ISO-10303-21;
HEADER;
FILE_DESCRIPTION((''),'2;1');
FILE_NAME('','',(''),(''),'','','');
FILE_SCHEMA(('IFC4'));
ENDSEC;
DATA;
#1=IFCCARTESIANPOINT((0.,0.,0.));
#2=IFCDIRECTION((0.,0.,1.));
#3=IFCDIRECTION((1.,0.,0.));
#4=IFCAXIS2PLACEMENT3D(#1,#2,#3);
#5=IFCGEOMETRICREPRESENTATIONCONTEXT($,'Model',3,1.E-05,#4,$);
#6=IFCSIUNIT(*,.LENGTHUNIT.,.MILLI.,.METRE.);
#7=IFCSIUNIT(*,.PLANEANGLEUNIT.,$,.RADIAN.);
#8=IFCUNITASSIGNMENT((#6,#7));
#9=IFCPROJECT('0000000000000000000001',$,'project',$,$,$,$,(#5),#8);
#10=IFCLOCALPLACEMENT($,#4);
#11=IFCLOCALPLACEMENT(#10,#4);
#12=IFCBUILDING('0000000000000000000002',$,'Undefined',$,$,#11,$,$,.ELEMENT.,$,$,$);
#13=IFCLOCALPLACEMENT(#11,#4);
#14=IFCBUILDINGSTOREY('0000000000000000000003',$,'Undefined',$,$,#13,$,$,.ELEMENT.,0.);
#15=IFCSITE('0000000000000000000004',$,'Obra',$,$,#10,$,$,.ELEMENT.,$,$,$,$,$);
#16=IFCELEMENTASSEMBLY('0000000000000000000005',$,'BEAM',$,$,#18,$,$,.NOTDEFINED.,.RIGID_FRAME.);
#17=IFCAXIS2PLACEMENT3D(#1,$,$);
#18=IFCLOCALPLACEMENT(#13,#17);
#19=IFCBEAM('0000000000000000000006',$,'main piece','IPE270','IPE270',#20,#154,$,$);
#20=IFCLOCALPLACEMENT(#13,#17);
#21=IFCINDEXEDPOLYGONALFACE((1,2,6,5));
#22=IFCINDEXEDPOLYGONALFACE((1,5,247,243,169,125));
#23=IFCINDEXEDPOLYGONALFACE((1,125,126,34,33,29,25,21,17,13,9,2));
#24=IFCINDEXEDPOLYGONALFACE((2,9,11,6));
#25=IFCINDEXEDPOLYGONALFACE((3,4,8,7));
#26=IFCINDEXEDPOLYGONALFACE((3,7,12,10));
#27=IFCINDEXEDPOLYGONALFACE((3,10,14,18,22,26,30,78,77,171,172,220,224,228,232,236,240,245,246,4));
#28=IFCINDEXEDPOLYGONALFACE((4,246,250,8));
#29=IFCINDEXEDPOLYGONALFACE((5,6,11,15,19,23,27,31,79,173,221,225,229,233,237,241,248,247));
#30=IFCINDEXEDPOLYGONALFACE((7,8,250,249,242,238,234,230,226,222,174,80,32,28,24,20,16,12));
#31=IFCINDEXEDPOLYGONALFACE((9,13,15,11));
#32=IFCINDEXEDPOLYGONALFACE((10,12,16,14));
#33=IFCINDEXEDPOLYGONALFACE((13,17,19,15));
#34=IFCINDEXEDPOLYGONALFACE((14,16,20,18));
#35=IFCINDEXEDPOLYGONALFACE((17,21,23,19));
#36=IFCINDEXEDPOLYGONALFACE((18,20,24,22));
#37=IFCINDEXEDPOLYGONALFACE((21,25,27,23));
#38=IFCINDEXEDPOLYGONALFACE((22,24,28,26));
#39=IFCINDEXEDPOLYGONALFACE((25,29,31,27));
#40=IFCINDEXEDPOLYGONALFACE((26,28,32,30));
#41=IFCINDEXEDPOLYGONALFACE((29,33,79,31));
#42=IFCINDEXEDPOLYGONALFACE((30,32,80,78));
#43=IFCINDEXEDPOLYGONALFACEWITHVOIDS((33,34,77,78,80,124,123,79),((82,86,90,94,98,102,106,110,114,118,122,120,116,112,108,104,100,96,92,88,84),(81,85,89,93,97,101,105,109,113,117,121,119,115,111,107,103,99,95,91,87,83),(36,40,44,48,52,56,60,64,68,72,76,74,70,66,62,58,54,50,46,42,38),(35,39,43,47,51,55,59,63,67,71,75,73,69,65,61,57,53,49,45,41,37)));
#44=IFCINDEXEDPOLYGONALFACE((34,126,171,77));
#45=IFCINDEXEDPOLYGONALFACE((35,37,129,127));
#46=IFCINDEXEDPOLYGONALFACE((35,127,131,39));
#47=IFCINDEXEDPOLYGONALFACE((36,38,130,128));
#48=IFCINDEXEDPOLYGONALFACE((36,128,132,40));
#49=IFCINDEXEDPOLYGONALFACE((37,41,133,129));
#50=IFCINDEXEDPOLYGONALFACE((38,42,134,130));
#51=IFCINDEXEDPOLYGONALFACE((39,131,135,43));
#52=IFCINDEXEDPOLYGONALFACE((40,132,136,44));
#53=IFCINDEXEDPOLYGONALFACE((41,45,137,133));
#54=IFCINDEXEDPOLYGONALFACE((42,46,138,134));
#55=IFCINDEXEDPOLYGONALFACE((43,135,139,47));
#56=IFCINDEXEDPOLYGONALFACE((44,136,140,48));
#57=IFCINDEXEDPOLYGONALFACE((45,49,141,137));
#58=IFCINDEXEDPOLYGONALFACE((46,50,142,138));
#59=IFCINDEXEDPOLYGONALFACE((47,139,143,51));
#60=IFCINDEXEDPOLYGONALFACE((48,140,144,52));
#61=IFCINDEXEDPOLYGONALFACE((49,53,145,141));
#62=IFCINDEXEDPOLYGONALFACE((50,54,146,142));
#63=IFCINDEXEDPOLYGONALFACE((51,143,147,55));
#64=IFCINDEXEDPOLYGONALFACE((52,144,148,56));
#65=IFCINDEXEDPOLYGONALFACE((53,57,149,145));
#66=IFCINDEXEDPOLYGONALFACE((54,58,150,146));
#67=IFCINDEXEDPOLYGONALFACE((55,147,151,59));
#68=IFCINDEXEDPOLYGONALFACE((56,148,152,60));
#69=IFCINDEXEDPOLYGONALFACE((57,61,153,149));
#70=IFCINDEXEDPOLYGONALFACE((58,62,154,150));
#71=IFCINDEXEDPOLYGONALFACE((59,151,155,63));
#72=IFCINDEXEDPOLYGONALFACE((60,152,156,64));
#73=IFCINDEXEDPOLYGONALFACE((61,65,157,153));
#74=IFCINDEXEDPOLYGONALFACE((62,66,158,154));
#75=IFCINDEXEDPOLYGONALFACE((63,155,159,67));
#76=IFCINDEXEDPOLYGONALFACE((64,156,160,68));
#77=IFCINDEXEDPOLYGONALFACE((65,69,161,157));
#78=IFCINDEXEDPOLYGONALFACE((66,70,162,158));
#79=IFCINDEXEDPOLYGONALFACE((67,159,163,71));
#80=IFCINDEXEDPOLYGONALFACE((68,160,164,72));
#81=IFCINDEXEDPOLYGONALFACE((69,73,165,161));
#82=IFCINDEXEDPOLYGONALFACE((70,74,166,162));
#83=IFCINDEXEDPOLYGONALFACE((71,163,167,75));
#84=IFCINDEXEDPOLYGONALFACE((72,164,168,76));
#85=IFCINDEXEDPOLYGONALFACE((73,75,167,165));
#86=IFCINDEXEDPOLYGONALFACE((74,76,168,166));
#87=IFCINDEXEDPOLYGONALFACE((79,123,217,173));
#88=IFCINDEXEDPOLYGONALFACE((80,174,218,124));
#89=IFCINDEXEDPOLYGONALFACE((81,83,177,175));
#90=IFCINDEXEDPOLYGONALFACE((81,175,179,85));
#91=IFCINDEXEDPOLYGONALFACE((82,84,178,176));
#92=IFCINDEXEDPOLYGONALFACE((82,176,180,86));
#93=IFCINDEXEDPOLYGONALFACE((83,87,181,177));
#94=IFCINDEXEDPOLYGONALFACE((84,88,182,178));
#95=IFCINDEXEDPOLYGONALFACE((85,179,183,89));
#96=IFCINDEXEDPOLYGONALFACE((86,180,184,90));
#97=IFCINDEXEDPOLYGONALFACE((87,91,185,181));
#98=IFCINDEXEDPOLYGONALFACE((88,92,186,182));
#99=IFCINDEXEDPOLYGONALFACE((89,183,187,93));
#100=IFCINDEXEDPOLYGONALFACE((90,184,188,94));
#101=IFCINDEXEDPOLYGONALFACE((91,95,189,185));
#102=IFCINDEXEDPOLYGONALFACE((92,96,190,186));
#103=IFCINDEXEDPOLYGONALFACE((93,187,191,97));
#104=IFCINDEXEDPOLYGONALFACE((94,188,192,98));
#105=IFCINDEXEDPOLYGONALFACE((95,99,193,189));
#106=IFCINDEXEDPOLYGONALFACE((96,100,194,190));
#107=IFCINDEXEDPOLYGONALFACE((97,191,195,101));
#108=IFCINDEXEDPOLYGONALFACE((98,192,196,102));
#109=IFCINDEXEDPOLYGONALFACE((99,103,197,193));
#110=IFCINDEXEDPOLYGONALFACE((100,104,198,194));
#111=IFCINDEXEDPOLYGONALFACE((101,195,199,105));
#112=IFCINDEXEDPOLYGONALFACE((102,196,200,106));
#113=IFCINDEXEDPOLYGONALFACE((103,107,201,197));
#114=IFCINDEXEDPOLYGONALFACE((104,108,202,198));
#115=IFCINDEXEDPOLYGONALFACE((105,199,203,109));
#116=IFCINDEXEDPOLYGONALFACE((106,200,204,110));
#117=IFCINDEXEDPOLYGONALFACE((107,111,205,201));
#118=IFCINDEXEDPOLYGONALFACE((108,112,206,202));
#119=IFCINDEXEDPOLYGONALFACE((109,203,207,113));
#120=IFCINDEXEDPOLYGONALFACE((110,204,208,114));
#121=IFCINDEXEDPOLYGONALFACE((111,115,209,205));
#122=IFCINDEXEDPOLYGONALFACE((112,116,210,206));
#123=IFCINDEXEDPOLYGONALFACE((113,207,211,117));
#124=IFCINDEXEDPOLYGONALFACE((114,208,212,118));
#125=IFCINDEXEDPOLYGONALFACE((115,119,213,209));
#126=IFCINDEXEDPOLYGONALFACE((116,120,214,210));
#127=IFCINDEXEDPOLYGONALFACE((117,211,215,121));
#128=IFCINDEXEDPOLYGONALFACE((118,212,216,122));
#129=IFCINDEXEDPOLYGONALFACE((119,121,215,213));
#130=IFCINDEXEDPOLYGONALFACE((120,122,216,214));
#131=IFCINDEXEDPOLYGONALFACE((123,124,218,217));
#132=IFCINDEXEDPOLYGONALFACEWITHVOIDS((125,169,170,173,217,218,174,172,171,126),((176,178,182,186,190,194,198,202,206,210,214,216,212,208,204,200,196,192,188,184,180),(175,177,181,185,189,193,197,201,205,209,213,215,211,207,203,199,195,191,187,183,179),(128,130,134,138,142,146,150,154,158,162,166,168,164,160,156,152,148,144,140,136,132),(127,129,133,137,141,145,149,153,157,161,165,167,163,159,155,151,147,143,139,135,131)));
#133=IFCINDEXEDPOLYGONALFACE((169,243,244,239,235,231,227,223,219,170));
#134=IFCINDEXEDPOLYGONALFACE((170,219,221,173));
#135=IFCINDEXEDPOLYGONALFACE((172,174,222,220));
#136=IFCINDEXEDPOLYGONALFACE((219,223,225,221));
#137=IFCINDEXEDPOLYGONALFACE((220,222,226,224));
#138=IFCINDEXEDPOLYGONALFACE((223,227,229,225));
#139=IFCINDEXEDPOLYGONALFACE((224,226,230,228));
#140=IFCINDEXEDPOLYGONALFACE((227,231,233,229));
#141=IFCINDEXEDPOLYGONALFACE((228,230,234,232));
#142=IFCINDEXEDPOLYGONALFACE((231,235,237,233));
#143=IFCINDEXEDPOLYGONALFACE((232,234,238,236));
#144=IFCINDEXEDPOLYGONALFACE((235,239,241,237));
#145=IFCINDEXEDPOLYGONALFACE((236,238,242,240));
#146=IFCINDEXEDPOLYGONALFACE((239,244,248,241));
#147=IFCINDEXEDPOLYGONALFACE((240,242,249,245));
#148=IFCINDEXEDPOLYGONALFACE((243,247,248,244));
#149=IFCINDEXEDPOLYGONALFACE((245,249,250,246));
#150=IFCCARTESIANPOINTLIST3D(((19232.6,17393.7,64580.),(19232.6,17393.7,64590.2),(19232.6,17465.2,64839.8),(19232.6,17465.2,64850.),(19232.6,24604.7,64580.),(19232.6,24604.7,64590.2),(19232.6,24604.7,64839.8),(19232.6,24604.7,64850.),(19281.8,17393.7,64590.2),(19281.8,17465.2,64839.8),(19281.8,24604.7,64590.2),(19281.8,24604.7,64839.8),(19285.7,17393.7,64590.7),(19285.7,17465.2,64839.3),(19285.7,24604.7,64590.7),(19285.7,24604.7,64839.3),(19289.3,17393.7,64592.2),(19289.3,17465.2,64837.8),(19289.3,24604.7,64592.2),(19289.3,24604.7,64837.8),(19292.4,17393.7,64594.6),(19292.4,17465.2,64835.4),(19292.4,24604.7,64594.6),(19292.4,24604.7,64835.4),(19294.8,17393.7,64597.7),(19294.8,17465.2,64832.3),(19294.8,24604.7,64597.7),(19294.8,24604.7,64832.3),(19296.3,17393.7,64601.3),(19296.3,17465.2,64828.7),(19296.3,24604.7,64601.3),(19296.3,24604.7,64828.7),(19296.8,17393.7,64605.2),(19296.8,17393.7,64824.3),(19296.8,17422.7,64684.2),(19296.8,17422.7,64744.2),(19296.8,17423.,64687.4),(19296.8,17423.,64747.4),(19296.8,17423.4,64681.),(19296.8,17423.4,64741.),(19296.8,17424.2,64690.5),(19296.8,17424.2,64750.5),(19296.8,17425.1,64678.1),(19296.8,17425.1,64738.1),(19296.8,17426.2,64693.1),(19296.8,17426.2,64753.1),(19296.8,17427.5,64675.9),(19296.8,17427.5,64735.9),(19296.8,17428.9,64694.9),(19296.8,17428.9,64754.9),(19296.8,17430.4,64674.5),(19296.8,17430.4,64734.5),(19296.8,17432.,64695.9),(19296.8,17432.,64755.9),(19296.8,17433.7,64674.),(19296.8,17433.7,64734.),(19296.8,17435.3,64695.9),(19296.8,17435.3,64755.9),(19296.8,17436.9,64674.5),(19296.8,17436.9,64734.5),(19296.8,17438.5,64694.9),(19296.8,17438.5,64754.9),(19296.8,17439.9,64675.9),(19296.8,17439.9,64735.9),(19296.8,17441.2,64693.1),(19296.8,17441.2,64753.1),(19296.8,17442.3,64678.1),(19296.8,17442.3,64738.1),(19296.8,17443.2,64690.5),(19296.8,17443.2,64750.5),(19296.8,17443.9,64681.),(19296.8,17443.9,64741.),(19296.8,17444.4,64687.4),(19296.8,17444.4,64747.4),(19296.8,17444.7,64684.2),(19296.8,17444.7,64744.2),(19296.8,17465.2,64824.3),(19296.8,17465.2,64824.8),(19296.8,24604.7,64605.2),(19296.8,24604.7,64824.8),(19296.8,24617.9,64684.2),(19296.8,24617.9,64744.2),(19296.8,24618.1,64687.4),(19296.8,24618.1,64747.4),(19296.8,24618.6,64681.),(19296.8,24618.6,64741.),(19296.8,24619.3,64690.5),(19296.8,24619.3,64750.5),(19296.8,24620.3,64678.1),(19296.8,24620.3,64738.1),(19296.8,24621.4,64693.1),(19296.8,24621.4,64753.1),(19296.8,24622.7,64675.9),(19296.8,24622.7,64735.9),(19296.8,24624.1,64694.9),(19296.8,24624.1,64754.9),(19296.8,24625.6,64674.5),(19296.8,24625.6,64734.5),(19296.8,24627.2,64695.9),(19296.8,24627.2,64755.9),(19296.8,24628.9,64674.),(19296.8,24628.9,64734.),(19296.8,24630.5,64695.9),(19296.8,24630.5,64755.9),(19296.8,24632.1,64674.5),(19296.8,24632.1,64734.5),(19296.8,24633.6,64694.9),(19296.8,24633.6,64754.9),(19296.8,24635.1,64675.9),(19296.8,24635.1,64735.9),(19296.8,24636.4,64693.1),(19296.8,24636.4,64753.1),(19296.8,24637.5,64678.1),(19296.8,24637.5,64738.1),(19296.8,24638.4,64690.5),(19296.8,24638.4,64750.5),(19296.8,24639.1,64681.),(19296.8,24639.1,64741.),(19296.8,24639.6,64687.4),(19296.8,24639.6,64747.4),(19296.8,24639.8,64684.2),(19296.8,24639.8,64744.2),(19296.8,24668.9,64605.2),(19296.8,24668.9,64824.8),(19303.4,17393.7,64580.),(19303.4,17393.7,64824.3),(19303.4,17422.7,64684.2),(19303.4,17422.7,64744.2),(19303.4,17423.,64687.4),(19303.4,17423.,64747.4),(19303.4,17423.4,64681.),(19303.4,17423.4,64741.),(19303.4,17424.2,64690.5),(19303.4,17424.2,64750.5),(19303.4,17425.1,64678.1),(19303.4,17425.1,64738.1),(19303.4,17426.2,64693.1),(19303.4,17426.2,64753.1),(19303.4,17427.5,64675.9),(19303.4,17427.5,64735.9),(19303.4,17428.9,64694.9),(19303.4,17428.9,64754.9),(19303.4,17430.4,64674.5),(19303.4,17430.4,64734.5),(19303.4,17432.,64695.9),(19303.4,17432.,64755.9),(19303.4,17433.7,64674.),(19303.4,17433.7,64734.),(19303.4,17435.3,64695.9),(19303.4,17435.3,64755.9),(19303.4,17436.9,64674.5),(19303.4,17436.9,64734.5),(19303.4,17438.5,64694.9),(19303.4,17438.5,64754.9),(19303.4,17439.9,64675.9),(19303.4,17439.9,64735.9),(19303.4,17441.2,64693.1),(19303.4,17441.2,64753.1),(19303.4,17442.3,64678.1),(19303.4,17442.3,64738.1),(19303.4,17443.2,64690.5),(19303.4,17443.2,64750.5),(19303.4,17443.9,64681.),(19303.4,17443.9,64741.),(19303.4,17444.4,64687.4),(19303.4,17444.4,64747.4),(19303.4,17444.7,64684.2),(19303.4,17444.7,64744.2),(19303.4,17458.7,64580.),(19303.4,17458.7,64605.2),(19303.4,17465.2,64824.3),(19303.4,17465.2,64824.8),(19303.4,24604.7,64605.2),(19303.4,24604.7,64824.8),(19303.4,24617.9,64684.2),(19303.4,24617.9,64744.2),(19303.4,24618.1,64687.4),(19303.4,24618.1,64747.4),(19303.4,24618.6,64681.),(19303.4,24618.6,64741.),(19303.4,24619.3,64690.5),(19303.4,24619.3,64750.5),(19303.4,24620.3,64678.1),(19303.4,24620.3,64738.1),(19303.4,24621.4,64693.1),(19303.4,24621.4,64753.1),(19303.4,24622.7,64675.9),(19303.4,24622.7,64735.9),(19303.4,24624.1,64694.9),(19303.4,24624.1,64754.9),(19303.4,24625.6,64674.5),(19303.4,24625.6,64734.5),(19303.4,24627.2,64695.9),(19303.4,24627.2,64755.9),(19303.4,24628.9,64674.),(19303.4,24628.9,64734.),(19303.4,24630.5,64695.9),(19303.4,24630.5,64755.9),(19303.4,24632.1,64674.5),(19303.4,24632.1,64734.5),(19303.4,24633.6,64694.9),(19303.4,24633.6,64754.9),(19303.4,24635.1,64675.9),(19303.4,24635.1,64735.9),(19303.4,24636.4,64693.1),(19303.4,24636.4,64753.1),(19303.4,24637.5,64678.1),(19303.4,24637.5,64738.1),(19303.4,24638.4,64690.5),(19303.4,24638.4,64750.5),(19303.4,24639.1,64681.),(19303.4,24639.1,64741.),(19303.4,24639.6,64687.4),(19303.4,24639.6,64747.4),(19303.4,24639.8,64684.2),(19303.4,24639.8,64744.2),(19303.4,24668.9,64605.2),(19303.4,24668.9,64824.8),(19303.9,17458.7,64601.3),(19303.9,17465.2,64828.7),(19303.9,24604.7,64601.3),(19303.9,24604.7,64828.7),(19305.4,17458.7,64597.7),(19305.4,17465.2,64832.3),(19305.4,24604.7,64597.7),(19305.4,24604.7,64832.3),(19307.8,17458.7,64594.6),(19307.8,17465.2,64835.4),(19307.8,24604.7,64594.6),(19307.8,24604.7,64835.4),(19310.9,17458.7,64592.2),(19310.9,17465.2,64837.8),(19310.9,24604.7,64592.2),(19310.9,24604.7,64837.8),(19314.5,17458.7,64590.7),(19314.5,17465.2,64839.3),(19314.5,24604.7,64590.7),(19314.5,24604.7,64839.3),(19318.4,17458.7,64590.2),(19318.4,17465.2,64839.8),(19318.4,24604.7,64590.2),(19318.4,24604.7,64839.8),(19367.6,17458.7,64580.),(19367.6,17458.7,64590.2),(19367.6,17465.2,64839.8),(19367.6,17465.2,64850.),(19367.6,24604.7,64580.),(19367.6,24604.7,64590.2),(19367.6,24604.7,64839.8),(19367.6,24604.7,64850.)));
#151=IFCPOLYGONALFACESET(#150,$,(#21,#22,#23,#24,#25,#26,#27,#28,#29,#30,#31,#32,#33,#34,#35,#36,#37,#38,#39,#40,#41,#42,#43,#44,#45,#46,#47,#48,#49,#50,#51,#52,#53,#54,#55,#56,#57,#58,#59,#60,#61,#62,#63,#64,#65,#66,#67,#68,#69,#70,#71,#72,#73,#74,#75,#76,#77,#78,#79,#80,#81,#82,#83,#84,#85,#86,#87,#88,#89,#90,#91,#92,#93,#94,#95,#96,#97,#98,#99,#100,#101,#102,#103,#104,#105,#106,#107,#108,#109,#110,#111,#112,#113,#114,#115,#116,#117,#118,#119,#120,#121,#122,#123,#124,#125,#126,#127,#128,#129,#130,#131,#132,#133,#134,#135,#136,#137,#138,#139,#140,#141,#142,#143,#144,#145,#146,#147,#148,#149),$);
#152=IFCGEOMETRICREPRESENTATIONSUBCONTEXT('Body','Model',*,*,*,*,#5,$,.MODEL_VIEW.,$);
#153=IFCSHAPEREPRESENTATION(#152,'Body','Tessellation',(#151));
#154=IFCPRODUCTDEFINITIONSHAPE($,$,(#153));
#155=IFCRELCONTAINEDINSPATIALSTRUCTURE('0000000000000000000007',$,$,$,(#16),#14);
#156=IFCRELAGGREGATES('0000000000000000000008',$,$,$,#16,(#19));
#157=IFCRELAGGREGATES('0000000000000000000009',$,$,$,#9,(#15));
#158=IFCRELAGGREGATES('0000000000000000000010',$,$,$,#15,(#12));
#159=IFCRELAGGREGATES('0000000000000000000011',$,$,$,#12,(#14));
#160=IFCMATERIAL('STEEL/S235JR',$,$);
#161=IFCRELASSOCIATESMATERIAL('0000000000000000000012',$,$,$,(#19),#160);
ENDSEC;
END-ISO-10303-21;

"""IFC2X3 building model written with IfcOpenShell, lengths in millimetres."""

from ifc_helpers import new_model, si_unit, frame, origin_with_axes, origin_2d_with_axis, place, context, subcontext, project, spatial, rectangle, circle, i_section, extrude, clip, halfspace, source, transform, mapped, material, element, aggregate, save


model = new_model("IFC2X3")

# Units and contexts
model_context = context("Model", 3, precision=1e-05, world=origin_with_axes())
body_context = subcontext(model_context, "Body", "Model", "MODEL_VIEW")
ifc_project = project(units=[si_unit("LENGTHUNIT", "METRE", prefix="MILLI"), si_unit("PLANEANGLEUNIT", "RADIAN")], contexts=[model_context])

# Site, building, storey
site_placement = place(None, origin_with_axes())
site = spatial("IfcSite", under=ifc_project, at=site_placement, Name="Obra", CompositionType="ELEMENT")
building_placement = place(site_placement, origin_with_axes())
building = spatial("IfcBuilding", under=site, at=building_placement, Name="Undefined", CompositionType="ELEMENT")
storey_placement = place(building_placement, origin_with_axes())
storey = spatial("IfcBuildingStorey", under=building, at=storey_placement, Name="Undefined", CompositionType="ELEMENT", Elevation=0.0)

# Shared definitions
ifc_material_1 = material(Name="STEEL/S235JR")

# Element assembly, beam, openings
assembly_1_placement = place(storey_placement, origin_with_axes())
assembly_1 = element("IfcElementAssembly", 1, at=assembly_1_placement, inside=storey, Name="BEAM", AssemblyPlace="NOTDEFINED", PredefinedType="RIGID_FRAME")
beam_1_placement = place(assembly_1_placement, frame((19300.1, 17475.1, 64715.0), z_axis=(0.0, 0.0, 1.0), x_axis=(0.0, 1.0, 0.0)))
beam_1 = element("IfcBeam", 2, at=beam_1_placement, material=ifc_material_1, Name="main piece", Description="IPE270", ObjectType="IPE270", context=body_context, shape_type="Clipping", body=[
    clip(clip(extrude(i_section(OverallWidth=135.0, OverallDepth=270.0, WebThickness=6.6, FlangeThickness=10.2, FilletRadius=15.0, at=origin_2d_with_axis()), frame((7193.7, 0.0, 0.0), z_axis=(-1.0, 0.0, 0.0), x_axis=(0.0, -1.0, 0.0)), (0.0, 0.0, 1.0), 7275.2), halfspace(frame((7193.7, 0.0, -235.0), z_axis=(-1.0, -0.000002, 0.0), x_axis=(-0.000002, 1.0, 0.0)), True)), halfspace(frame((-81.4, 0.0, -235.0), z_axis=(1.0, 0.0, 0.0), x_axis=(0.0, -1.0, 0.0)), True)),
])
opening_1_placement = place(assembly_1_placement, frame((19300.1, 17475.1, 64715.0), z_axis=(0.0, 0.0, 1.0), x_axis=(0.0, 1.0, 0.0)))
element("IfcOpeningElement", 3, at=opening_1_placement, cuts=beam_1, ObjectType="Recess", context=body_context, shape_type="SweptSolid", body=[
    extrude(rectangle(XDim=26.2, YDim=76.2, at=origin_2d_with_axis()), frame((7167.6, 68.5, -122.9), z_axis=(0.000002, -1.0, 0.0), x_axis=(0.0, 0.0, -1.0)), (0.0, 0.0, 1.0), 137.0),
])
opening_2_placement = place(assembly_1_placement, frame((19300.1, 17475.1, 64715.0), z_axis=(0.0, 0.0, 1.0), x_axis=(0.0, 1.0, 0.0)))
element("IfcOpeningElement", 4, at=opening_2_placement, cuts=beam_1, ObjectType="Recess", context=body_context, shape_type="SweptSolid", body=[
    extrude(rectangle(XDim=26.2, YDim=76.2, at=origin_2d_with_axis()), frame((7167.6, 68.5, 122.9), z_axis=(0.000002, -1.0, 0.0), x_axis=(0.0, 0.0, -1.0)), (0.0, 0.0, 1.0), 137.0),
])
opening_3_placement = place(assembly_1_placement, frame((19300.1, 17475.1, 64715.0), z_axis=(0.0, 0.0, 1.0), x_axis=(0.0, 1.0, 0.0)))
element("IfcOpeningElement", 5, at=opening_3_placement, cuts=beam_1, ObjectType="Recess", context=body_context, shape_type="SweptSolid", body=[
    extrude(rectangle(XDim=75.0, YDim=300.0, at=origin_2d_with_axis()), frame((-53.9, -153.3, 124.3), z_axis=(0.0, 0.0, -1.0), x_axis=(1.0, 0.0, 0.0)), (0.0, 0.0, 1.0), 278.6),
])
opening_4_placement = place(assembly_1_placement, frame((19300.1, 17475.1, 64715.0), z_axis=(0.0, 0.0, 1.0), x_axis=(0.0, 1.0, 0.0)))
element("IfcOpeningElement", 6, at=opening_4_placement, cuts=beam_1, ObjectType="Recess", context=body_context, shape_type="SweptSolid", body=[
    extrude(rectangle(XDim=26.7, YDim=83.5, at=origin_2d_with_axis()), frame((-51.7, -68.5, 122.7), z_axis=(0.0, 1.0, 0.0), x_axis=(0.0, 0.0, -1.0)), (0.0, 0.0, 1.0), 137.0),
])
shared_shape_1 = source(origin_with_axes(), body_context, "Body", "SweptSolid", [
    extrude(circle(Radius=11.0, at=origin_2d_with_axis()), frame((0.0, -3.4, 0.0), z_axis=(0.0, 1.0, 0.0), x_axis=(1.0, 0.0, 0.0)), (0.0, 0.0, 1.0), 6.8),
])
opening_5_placement = place(assembly_1_placement, frame((19300.1, 24668.9, 64850.0), z_axis=(0.000002, -1.0, 0.0), x_axis=(0.0, 0.0, -1.0)))
element("IfcOpeningElement", 7, at=opening_5_placement, cuts=beam_1, ObjectType="Opening", context=body_context, shape_type="MappedRepresentation", body=[
    mapped(shared_shape_1, transform((105.0, 0.0, 40.0))),
    mapped(shared_shape_1, transform((165.0, 0.0, 40.0))),
])
opening_6_placement = place(assembly_1_placement, frame((19300.1, 17393.7, 64850.0), z_axis=(0.0, 1.0, 0.0), x_axis=(0.0, 0.0, -1.0)))
element("IfcOpeningElement", 8, at=opening_6_placement, cuts=beam_1, ObjectType="Opening", context=body_context, shape_type="MappedRepresentation", body=[
    mapped(shared_shape_1, transform((105.0, 0.0, 40.0))),
    mapped(shared_shape_1, transform((165.0, 0.0, 40.0))),
])
aggregate(assembly_1, [beam_1])

save(model, "model.ifc")
